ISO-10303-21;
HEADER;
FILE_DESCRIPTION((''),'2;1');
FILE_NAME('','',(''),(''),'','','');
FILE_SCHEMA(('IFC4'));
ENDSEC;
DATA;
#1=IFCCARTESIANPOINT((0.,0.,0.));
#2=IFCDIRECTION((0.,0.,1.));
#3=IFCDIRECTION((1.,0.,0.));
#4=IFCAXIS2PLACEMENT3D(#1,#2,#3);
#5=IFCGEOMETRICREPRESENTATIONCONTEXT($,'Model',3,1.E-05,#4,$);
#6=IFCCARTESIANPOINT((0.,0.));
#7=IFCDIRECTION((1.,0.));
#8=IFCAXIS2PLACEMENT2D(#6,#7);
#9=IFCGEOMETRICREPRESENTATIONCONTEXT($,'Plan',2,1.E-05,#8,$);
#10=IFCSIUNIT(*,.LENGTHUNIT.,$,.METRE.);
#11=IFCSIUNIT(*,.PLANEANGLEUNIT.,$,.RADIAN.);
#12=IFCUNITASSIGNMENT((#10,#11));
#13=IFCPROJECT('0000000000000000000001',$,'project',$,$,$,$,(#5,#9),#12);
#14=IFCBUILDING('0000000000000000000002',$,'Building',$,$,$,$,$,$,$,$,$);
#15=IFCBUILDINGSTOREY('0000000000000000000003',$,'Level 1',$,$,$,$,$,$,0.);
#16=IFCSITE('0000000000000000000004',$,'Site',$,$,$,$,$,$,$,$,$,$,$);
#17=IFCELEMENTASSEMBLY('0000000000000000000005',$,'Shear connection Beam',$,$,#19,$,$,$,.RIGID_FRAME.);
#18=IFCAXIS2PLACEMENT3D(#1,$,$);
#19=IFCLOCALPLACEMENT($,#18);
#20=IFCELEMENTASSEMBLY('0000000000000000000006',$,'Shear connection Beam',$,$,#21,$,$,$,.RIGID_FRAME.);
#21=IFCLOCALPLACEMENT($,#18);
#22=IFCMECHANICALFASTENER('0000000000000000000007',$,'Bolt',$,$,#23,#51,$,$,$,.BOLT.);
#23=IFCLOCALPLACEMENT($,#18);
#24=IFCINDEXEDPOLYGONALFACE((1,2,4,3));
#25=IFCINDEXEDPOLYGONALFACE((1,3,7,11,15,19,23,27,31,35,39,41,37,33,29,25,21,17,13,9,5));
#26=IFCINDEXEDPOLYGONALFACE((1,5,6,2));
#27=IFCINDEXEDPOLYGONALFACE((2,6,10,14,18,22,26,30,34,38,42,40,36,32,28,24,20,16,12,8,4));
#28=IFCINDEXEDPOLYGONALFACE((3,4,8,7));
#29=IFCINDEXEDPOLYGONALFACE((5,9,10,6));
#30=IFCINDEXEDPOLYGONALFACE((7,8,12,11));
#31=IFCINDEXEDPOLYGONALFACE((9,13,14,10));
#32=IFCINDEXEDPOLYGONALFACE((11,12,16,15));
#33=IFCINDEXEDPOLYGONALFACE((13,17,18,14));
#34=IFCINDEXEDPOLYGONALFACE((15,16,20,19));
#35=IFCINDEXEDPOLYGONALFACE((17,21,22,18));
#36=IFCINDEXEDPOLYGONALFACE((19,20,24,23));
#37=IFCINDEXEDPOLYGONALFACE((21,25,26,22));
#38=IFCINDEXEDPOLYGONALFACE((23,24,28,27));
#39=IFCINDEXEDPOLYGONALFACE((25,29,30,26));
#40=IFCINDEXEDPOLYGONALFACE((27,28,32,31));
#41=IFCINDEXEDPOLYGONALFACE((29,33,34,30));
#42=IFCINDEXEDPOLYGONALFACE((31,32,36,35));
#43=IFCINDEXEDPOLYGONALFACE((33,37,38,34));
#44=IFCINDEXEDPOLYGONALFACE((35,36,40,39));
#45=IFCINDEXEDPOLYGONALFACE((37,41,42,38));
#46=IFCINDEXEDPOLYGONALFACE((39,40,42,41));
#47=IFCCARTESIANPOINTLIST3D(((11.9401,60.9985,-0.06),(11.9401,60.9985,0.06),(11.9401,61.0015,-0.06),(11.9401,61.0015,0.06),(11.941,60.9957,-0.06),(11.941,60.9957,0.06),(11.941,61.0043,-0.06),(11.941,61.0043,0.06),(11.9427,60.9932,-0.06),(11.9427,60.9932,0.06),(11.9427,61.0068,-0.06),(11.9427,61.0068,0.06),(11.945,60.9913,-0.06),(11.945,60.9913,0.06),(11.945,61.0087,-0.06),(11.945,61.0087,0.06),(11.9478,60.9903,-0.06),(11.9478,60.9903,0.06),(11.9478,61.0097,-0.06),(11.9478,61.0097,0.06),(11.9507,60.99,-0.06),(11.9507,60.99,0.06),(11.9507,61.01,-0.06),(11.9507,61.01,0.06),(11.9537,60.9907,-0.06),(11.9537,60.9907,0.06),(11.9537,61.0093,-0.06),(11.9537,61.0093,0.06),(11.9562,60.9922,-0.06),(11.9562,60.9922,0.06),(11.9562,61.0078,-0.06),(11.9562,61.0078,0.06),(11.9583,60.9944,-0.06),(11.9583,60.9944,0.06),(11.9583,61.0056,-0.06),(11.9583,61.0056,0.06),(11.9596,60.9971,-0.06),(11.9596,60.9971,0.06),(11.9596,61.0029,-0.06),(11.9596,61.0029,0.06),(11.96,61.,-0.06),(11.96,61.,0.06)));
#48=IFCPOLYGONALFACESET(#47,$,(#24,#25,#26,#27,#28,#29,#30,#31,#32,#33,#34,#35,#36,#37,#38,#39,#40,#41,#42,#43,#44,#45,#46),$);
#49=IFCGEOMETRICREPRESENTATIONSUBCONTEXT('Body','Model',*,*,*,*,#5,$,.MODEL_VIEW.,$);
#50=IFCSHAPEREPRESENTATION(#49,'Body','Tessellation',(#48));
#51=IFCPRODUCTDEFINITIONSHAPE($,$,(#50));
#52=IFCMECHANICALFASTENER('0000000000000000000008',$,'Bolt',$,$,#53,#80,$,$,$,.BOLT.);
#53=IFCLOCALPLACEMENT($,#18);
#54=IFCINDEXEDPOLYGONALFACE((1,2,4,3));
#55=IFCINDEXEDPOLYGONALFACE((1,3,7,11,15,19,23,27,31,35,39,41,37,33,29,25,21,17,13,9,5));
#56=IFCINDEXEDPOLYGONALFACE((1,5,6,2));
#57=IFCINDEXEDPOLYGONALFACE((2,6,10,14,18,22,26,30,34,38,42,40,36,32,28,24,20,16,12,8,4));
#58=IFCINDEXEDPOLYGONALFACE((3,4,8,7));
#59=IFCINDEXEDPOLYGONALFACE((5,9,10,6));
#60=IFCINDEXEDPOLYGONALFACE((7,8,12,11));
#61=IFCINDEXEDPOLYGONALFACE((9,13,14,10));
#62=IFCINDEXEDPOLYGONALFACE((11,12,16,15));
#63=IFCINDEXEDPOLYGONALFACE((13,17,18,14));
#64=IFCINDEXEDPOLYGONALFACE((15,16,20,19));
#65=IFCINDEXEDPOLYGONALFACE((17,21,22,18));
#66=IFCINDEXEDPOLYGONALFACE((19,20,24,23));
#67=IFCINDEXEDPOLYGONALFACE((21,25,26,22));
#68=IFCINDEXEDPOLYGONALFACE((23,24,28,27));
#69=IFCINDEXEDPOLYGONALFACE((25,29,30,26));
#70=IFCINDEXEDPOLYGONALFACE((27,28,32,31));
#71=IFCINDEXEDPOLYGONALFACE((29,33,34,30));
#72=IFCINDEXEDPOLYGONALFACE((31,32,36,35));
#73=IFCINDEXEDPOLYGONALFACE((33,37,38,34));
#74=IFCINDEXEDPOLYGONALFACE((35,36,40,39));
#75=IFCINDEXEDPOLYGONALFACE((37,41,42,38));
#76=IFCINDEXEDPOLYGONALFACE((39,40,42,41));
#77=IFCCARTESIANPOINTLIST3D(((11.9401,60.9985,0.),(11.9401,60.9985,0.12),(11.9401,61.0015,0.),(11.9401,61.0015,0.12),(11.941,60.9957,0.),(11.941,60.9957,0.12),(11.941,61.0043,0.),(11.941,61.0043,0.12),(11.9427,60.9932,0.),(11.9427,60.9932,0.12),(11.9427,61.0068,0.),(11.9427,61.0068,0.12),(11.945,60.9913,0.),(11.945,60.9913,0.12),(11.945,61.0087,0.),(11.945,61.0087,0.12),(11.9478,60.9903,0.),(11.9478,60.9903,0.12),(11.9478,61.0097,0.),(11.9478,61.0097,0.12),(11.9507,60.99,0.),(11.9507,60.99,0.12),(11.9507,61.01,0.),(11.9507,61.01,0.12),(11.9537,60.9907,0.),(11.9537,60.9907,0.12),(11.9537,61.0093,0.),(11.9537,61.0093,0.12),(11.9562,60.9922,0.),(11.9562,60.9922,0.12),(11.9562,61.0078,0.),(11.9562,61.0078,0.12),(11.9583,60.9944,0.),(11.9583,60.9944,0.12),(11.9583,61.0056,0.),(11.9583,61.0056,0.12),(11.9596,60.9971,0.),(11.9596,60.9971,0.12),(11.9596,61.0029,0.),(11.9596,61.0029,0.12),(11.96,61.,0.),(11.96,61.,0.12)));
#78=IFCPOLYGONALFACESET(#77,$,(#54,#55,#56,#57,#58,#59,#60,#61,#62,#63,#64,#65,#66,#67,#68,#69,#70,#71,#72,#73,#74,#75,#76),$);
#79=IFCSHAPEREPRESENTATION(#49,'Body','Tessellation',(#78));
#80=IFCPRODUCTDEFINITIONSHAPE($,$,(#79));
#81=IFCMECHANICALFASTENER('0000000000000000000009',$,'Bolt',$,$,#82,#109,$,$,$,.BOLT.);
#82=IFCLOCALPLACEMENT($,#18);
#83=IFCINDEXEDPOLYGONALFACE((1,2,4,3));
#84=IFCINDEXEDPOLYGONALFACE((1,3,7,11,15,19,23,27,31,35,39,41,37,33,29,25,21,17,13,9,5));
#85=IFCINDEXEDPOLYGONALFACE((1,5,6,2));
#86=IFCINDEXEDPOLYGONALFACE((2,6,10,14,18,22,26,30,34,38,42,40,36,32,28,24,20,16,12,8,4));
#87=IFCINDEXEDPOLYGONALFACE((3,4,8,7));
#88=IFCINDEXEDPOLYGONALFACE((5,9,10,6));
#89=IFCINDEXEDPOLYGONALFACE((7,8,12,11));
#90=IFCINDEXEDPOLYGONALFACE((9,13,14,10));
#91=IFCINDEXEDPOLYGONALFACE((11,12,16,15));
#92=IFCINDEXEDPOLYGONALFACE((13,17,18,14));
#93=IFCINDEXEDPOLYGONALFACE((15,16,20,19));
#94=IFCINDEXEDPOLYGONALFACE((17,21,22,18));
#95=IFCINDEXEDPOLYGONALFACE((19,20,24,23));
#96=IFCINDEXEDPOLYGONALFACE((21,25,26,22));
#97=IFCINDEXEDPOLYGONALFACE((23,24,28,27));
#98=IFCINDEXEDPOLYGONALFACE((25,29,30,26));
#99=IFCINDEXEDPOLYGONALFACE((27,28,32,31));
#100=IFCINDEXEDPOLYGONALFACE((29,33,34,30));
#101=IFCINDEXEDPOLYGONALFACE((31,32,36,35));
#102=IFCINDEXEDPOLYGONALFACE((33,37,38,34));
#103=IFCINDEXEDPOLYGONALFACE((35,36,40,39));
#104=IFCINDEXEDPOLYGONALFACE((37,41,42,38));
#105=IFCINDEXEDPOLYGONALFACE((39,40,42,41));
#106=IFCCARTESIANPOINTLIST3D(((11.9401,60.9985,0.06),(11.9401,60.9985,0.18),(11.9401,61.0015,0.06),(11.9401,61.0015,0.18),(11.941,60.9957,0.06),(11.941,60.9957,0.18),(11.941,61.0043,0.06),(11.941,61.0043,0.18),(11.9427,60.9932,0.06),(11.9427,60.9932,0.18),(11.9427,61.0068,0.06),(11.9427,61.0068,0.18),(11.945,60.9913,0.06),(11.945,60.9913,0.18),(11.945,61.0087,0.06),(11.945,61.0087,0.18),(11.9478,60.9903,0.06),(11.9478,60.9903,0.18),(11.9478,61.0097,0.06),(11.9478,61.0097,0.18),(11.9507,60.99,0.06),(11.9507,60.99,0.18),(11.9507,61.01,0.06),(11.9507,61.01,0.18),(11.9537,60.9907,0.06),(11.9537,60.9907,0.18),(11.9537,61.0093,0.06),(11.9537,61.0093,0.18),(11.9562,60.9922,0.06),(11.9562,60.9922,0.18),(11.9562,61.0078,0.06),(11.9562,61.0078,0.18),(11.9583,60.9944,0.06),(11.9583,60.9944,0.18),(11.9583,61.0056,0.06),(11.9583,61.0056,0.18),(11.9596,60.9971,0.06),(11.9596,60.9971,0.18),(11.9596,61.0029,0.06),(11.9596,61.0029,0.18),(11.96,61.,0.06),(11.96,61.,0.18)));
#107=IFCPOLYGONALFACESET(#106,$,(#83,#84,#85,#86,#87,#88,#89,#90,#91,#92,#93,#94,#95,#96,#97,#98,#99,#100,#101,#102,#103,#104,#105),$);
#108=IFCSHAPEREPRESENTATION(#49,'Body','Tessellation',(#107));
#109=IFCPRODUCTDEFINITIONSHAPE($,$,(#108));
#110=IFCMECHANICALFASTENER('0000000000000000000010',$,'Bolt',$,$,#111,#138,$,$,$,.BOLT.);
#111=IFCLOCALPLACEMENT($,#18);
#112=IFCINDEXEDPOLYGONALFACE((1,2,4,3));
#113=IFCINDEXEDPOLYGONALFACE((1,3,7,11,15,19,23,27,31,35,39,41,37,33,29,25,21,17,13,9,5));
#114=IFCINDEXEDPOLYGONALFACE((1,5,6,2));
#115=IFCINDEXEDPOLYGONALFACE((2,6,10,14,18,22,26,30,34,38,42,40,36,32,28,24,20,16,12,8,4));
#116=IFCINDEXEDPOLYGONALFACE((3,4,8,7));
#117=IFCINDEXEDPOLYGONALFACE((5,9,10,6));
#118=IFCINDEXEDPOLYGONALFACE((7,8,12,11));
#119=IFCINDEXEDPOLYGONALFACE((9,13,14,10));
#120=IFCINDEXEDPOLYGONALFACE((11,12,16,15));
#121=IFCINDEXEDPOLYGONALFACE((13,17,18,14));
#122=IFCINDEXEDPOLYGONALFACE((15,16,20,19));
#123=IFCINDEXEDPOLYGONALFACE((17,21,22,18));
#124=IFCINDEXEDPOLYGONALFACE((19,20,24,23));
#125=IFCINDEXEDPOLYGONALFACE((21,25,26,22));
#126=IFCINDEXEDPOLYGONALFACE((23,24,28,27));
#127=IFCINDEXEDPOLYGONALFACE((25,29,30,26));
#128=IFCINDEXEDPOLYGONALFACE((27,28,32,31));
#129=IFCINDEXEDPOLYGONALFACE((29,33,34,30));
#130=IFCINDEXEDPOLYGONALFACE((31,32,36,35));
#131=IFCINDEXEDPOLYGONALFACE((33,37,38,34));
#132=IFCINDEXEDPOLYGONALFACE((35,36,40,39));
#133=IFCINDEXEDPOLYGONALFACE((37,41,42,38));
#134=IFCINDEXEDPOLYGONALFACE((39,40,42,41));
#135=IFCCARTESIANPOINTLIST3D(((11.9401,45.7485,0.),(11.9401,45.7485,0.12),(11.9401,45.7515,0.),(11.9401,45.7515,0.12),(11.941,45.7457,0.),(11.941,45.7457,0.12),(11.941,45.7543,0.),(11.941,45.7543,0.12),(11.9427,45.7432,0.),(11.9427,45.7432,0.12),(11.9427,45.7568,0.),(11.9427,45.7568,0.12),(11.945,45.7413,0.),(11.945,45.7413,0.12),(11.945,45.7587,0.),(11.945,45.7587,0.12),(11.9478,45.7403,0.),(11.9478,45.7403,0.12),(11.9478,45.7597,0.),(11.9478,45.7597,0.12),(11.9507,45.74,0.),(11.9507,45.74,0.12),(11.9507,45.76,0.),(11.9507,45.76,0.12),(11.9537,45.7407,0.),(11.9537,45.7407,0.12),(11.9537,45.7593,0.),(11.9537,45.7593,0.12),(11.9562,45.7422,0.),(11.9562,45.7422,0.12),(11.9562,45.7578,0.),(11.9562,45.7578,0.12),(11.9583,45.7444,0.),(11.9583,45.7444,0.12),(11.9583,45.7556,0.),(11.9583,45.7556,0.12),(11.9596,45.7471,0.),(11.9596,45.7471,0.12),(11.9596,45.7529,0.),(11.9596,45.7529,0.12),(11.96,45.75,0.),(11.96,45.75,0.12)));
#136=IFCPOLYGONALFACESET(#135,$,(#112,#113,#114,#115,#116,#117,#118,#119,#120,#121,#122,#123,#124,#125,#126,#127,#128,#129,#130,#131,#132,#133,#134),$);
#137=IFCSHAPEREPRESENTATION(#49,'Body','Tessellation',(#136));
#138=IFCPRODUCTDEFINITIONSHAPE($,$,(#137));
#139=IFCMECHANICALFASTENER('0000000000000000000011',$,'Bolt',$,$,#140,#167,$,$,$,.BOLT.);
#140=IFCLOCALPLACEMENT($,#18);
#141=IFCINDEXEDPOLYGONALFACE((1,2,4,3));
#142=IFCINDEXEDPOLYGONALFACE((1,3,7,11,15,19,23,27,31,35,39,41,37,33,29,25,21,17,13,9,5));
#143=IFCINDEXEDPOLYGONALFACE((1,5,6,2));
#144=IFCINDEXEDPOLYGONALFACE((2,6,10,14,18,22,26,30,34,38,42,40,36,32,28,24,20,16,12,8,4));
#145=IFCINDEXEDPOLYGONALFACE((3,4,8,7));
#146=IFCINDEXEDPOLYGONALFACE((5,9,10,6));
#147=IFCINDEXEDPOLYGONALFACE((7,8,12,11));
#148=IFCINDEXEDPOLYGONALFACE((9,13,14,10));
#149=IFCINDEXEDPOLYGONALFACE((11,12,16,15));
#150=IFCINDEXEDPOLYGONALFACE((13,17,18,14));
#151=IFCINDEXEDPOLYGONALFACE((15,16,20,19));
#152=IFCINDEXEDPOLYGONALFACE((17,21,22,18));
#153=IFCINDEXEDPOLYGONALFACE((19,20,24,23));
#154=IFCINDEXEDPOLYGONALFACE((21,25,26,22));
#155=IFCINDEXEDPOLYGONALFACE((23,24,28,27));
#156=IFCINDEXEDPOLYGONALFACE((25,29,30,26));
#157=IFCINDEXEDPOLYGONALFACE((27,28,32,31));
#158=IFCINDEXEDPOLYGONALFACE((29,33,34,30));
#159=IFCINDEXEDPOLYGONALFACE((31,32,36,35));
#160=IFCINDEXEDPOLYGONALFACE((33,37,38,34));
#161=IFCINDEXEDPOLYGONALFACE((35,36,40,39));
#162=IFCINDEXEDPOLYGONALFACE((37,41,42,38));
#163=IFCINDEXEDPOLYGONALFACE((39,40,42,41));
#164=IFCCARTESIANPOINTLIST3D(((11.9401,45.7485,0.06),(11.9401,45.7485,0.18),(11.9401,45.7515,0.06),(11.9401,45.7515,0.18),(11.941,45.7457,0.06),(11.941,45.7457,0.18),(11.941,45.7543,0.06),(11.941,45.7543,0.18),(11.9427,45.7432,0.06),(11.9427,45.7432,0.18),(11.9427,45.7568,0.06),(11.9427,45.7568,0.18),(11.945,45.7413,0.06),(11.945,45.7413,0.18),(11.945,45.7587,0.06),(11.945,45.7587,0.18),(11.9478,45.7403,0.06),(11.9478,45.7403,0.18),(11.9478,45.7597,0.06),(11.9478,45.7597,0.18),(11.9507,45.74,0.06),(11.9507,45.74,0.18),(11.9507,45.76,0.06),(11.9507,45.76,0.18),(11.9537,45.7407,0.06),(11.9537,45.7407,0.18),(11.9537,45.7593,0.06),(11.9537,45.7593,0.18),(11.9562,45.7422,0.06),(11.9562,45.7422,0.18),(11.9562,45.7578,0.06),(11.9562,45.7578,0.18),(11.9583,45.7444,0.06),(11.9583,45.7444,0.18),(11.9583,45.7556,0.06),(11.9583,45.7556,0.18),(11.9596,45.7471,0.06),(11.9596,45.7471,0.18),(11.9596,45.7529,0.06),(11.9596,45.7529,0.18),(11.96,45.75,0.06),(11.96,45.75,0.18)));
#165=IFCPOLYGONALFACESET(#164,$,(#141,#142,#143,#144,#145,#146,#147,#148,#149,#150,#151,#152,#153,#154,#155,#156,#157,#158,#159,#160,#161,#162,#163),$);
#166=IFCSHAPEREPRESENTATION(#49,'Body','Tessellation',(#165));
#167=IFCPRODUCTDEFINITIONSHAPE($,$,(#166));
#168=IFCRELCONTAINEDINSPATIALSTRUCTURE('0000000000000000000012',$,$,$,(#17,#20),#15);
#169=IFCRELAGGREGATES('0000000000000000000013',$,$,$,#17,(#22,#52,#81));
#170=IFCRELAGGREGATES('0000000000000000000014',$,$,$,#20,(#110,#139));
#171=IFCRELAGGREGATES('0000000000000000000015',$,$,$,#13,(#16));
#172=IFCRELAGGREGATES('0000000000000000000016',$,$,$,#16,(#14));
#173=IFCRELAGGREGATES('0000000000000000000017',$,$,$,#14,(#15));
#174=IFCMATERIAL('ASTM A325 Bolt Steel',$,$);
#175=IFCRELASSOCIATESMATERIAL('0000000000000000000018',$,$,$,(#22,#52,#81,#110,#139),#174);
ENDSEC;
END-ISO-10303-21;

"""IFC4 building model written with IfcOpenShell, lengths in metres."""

from ifc_helpers import new_model, si_unit, frame, origin_with_axes, origin_2d, origin_2d_with_axis, place, context, subcontext, project, spatial, circle, extrude, material, element, aggregate, save


model = new_model("IFC4")

# Units and contexts
model_context = context("Model", 3, precision=1e-05, world=origin_with_axes())
plan_context = context("Plan", 2, precision=1e-05, world=origin_2d_with_axis())
body_context = subcontext(model_context, "Body", "Model", "MODEL_VIEW")
ifc_project = project(units=[si_unit("LENGTHUNIT", "METRE"), si_unit("PLANEANGLEUNIT", "RADIAN")], contexts=[model_context, plan_context])

# Site, building, storey
site = spatial("IfcSite", under=ifc_project, Name="Site")
building = spatial("IfcBuilding", under=site, Name="Building")
storey = spatial("IfcBuildingStorey", under=building, Name="Level 1", Elevation=0.0)

# Element assemblies
assembly_1 = element("IfcElementAssembly", 1, inside=storey, Name="Shear connection Beam", PredefinedType="RIGID_FRAME")
assembly_2 = element("IfcElementAssembly", 2, inside=storey, Name="Shear connection Beam", PredefinedType="RIGID_FRAME")

# Shared definitions
ifc_material_1 = material(Name="ASTM A325 Bolt Steel")

# Mechanical fasteners
mechanical_fastener_1_placement = place(None, frame((11.95, 61.0, -0.06), z_axis=(0.0, 0.0, 1.0), x_axis=(1.0, 0.0, 0.0)))
mechanical_fastener_1 = element("IfcMechanicalFastener", 3, at=mechanical_fastener_1_placement, material=ifc_material_1, Name="Bolt", PredefinedType="BOLT", context=body_context, shape_type="SweptSolid", body=[
    extrude(circle(Radius=0.01, at=origin_2d()), origin_with_axes(), (0.0, 0.0, 1.0), 0.12),
])
mechanical_fastener_2_placement = place(None, frame((11.95, 61.0, 0.0), z_axis=(0.0, 0.0, 1.0), x_axis=(1.0, 0.0, 0.0)))
mechanical_fastener_2 = element("IfcMechanicalFastener", 4, at=mechanical_fastener_2_placement, material=ifc_material_1, Name="Bolt", PredefinedType="BOLT", context=body_context, shape_type="SweptSolid", body=[
    extrude(circle(Radius=0.01, at=origin_2d()), origin_with_axes(), (0.0, 0.0, 1.0), 0.12),
])
mechanical_fastener_3_placement = place(None, frame((11.95, 61.0, 0.06), z_axis=(0.0, 0.0, 1.0), x_axis=(1.0, 0.0, 0.0)))
mechanical_fastener_3 = element("IfcMechanicalFastener", 5, at=mechanical_fastener_3_placement, material=ifc_material_1, Name="Bolt", PredefinedType="BOLT", context=body_context, shape_type="SweptSolid", body=[
    extrude(circle(Radius=0.01, at=origin_2d()), origin_with_axes(), (0.0, 0.0, 1.0), 0.12),
])
aggregate(assembly_1, [mechanical_fastener_1, mechanical_fastener_2, mechanical_fastener_3])
mechanical_fastener_4_placement = place(None, frame((11.95, 45.75, 0.0), z_axis=(0.0, 0.0, 1.0), x_axis=(1.0, 0.0, 0.0)))
mechanical_fastener_4 = element("IfcMechanicalFastener", 6, at=mechanical_fastener_4_placement, material=ifc_material_1, Name="Bolt", PredefinedType="BOLT", context=body_context, shape_type="SweptSolid", body=[
    extrude(circle(Radius=0.01, at=origin_2d()), origin_with_axes(), (0.0, 0.0, 1.0), 0.12),
])
mechanical_fastener_5_placement = place(None, frame((11.95, 45.75, 0.06), z_axis=(0.0, 0.0, 1.0), x_axis=(1.0, 0.0, 0.0)))
mechanical_fastener_5 = element("IfcMechanicalFastener", 7, at=mechanical_fastener_5_placement, material=ifc_material_1, Name="Bolt", PredefinedType="BOLT", context=body_context, shape_type="SweptSolid", body=[
    extrude(circle(Radius=0.01, at=origin_2d()), origin_with_axes(), (0.0, 0.0, 1.0), 0.12),
])
aggregate(assembly_2, [mechanical_fastener_4, mechanical_fastener_5])

save(model, "model.ifc")
